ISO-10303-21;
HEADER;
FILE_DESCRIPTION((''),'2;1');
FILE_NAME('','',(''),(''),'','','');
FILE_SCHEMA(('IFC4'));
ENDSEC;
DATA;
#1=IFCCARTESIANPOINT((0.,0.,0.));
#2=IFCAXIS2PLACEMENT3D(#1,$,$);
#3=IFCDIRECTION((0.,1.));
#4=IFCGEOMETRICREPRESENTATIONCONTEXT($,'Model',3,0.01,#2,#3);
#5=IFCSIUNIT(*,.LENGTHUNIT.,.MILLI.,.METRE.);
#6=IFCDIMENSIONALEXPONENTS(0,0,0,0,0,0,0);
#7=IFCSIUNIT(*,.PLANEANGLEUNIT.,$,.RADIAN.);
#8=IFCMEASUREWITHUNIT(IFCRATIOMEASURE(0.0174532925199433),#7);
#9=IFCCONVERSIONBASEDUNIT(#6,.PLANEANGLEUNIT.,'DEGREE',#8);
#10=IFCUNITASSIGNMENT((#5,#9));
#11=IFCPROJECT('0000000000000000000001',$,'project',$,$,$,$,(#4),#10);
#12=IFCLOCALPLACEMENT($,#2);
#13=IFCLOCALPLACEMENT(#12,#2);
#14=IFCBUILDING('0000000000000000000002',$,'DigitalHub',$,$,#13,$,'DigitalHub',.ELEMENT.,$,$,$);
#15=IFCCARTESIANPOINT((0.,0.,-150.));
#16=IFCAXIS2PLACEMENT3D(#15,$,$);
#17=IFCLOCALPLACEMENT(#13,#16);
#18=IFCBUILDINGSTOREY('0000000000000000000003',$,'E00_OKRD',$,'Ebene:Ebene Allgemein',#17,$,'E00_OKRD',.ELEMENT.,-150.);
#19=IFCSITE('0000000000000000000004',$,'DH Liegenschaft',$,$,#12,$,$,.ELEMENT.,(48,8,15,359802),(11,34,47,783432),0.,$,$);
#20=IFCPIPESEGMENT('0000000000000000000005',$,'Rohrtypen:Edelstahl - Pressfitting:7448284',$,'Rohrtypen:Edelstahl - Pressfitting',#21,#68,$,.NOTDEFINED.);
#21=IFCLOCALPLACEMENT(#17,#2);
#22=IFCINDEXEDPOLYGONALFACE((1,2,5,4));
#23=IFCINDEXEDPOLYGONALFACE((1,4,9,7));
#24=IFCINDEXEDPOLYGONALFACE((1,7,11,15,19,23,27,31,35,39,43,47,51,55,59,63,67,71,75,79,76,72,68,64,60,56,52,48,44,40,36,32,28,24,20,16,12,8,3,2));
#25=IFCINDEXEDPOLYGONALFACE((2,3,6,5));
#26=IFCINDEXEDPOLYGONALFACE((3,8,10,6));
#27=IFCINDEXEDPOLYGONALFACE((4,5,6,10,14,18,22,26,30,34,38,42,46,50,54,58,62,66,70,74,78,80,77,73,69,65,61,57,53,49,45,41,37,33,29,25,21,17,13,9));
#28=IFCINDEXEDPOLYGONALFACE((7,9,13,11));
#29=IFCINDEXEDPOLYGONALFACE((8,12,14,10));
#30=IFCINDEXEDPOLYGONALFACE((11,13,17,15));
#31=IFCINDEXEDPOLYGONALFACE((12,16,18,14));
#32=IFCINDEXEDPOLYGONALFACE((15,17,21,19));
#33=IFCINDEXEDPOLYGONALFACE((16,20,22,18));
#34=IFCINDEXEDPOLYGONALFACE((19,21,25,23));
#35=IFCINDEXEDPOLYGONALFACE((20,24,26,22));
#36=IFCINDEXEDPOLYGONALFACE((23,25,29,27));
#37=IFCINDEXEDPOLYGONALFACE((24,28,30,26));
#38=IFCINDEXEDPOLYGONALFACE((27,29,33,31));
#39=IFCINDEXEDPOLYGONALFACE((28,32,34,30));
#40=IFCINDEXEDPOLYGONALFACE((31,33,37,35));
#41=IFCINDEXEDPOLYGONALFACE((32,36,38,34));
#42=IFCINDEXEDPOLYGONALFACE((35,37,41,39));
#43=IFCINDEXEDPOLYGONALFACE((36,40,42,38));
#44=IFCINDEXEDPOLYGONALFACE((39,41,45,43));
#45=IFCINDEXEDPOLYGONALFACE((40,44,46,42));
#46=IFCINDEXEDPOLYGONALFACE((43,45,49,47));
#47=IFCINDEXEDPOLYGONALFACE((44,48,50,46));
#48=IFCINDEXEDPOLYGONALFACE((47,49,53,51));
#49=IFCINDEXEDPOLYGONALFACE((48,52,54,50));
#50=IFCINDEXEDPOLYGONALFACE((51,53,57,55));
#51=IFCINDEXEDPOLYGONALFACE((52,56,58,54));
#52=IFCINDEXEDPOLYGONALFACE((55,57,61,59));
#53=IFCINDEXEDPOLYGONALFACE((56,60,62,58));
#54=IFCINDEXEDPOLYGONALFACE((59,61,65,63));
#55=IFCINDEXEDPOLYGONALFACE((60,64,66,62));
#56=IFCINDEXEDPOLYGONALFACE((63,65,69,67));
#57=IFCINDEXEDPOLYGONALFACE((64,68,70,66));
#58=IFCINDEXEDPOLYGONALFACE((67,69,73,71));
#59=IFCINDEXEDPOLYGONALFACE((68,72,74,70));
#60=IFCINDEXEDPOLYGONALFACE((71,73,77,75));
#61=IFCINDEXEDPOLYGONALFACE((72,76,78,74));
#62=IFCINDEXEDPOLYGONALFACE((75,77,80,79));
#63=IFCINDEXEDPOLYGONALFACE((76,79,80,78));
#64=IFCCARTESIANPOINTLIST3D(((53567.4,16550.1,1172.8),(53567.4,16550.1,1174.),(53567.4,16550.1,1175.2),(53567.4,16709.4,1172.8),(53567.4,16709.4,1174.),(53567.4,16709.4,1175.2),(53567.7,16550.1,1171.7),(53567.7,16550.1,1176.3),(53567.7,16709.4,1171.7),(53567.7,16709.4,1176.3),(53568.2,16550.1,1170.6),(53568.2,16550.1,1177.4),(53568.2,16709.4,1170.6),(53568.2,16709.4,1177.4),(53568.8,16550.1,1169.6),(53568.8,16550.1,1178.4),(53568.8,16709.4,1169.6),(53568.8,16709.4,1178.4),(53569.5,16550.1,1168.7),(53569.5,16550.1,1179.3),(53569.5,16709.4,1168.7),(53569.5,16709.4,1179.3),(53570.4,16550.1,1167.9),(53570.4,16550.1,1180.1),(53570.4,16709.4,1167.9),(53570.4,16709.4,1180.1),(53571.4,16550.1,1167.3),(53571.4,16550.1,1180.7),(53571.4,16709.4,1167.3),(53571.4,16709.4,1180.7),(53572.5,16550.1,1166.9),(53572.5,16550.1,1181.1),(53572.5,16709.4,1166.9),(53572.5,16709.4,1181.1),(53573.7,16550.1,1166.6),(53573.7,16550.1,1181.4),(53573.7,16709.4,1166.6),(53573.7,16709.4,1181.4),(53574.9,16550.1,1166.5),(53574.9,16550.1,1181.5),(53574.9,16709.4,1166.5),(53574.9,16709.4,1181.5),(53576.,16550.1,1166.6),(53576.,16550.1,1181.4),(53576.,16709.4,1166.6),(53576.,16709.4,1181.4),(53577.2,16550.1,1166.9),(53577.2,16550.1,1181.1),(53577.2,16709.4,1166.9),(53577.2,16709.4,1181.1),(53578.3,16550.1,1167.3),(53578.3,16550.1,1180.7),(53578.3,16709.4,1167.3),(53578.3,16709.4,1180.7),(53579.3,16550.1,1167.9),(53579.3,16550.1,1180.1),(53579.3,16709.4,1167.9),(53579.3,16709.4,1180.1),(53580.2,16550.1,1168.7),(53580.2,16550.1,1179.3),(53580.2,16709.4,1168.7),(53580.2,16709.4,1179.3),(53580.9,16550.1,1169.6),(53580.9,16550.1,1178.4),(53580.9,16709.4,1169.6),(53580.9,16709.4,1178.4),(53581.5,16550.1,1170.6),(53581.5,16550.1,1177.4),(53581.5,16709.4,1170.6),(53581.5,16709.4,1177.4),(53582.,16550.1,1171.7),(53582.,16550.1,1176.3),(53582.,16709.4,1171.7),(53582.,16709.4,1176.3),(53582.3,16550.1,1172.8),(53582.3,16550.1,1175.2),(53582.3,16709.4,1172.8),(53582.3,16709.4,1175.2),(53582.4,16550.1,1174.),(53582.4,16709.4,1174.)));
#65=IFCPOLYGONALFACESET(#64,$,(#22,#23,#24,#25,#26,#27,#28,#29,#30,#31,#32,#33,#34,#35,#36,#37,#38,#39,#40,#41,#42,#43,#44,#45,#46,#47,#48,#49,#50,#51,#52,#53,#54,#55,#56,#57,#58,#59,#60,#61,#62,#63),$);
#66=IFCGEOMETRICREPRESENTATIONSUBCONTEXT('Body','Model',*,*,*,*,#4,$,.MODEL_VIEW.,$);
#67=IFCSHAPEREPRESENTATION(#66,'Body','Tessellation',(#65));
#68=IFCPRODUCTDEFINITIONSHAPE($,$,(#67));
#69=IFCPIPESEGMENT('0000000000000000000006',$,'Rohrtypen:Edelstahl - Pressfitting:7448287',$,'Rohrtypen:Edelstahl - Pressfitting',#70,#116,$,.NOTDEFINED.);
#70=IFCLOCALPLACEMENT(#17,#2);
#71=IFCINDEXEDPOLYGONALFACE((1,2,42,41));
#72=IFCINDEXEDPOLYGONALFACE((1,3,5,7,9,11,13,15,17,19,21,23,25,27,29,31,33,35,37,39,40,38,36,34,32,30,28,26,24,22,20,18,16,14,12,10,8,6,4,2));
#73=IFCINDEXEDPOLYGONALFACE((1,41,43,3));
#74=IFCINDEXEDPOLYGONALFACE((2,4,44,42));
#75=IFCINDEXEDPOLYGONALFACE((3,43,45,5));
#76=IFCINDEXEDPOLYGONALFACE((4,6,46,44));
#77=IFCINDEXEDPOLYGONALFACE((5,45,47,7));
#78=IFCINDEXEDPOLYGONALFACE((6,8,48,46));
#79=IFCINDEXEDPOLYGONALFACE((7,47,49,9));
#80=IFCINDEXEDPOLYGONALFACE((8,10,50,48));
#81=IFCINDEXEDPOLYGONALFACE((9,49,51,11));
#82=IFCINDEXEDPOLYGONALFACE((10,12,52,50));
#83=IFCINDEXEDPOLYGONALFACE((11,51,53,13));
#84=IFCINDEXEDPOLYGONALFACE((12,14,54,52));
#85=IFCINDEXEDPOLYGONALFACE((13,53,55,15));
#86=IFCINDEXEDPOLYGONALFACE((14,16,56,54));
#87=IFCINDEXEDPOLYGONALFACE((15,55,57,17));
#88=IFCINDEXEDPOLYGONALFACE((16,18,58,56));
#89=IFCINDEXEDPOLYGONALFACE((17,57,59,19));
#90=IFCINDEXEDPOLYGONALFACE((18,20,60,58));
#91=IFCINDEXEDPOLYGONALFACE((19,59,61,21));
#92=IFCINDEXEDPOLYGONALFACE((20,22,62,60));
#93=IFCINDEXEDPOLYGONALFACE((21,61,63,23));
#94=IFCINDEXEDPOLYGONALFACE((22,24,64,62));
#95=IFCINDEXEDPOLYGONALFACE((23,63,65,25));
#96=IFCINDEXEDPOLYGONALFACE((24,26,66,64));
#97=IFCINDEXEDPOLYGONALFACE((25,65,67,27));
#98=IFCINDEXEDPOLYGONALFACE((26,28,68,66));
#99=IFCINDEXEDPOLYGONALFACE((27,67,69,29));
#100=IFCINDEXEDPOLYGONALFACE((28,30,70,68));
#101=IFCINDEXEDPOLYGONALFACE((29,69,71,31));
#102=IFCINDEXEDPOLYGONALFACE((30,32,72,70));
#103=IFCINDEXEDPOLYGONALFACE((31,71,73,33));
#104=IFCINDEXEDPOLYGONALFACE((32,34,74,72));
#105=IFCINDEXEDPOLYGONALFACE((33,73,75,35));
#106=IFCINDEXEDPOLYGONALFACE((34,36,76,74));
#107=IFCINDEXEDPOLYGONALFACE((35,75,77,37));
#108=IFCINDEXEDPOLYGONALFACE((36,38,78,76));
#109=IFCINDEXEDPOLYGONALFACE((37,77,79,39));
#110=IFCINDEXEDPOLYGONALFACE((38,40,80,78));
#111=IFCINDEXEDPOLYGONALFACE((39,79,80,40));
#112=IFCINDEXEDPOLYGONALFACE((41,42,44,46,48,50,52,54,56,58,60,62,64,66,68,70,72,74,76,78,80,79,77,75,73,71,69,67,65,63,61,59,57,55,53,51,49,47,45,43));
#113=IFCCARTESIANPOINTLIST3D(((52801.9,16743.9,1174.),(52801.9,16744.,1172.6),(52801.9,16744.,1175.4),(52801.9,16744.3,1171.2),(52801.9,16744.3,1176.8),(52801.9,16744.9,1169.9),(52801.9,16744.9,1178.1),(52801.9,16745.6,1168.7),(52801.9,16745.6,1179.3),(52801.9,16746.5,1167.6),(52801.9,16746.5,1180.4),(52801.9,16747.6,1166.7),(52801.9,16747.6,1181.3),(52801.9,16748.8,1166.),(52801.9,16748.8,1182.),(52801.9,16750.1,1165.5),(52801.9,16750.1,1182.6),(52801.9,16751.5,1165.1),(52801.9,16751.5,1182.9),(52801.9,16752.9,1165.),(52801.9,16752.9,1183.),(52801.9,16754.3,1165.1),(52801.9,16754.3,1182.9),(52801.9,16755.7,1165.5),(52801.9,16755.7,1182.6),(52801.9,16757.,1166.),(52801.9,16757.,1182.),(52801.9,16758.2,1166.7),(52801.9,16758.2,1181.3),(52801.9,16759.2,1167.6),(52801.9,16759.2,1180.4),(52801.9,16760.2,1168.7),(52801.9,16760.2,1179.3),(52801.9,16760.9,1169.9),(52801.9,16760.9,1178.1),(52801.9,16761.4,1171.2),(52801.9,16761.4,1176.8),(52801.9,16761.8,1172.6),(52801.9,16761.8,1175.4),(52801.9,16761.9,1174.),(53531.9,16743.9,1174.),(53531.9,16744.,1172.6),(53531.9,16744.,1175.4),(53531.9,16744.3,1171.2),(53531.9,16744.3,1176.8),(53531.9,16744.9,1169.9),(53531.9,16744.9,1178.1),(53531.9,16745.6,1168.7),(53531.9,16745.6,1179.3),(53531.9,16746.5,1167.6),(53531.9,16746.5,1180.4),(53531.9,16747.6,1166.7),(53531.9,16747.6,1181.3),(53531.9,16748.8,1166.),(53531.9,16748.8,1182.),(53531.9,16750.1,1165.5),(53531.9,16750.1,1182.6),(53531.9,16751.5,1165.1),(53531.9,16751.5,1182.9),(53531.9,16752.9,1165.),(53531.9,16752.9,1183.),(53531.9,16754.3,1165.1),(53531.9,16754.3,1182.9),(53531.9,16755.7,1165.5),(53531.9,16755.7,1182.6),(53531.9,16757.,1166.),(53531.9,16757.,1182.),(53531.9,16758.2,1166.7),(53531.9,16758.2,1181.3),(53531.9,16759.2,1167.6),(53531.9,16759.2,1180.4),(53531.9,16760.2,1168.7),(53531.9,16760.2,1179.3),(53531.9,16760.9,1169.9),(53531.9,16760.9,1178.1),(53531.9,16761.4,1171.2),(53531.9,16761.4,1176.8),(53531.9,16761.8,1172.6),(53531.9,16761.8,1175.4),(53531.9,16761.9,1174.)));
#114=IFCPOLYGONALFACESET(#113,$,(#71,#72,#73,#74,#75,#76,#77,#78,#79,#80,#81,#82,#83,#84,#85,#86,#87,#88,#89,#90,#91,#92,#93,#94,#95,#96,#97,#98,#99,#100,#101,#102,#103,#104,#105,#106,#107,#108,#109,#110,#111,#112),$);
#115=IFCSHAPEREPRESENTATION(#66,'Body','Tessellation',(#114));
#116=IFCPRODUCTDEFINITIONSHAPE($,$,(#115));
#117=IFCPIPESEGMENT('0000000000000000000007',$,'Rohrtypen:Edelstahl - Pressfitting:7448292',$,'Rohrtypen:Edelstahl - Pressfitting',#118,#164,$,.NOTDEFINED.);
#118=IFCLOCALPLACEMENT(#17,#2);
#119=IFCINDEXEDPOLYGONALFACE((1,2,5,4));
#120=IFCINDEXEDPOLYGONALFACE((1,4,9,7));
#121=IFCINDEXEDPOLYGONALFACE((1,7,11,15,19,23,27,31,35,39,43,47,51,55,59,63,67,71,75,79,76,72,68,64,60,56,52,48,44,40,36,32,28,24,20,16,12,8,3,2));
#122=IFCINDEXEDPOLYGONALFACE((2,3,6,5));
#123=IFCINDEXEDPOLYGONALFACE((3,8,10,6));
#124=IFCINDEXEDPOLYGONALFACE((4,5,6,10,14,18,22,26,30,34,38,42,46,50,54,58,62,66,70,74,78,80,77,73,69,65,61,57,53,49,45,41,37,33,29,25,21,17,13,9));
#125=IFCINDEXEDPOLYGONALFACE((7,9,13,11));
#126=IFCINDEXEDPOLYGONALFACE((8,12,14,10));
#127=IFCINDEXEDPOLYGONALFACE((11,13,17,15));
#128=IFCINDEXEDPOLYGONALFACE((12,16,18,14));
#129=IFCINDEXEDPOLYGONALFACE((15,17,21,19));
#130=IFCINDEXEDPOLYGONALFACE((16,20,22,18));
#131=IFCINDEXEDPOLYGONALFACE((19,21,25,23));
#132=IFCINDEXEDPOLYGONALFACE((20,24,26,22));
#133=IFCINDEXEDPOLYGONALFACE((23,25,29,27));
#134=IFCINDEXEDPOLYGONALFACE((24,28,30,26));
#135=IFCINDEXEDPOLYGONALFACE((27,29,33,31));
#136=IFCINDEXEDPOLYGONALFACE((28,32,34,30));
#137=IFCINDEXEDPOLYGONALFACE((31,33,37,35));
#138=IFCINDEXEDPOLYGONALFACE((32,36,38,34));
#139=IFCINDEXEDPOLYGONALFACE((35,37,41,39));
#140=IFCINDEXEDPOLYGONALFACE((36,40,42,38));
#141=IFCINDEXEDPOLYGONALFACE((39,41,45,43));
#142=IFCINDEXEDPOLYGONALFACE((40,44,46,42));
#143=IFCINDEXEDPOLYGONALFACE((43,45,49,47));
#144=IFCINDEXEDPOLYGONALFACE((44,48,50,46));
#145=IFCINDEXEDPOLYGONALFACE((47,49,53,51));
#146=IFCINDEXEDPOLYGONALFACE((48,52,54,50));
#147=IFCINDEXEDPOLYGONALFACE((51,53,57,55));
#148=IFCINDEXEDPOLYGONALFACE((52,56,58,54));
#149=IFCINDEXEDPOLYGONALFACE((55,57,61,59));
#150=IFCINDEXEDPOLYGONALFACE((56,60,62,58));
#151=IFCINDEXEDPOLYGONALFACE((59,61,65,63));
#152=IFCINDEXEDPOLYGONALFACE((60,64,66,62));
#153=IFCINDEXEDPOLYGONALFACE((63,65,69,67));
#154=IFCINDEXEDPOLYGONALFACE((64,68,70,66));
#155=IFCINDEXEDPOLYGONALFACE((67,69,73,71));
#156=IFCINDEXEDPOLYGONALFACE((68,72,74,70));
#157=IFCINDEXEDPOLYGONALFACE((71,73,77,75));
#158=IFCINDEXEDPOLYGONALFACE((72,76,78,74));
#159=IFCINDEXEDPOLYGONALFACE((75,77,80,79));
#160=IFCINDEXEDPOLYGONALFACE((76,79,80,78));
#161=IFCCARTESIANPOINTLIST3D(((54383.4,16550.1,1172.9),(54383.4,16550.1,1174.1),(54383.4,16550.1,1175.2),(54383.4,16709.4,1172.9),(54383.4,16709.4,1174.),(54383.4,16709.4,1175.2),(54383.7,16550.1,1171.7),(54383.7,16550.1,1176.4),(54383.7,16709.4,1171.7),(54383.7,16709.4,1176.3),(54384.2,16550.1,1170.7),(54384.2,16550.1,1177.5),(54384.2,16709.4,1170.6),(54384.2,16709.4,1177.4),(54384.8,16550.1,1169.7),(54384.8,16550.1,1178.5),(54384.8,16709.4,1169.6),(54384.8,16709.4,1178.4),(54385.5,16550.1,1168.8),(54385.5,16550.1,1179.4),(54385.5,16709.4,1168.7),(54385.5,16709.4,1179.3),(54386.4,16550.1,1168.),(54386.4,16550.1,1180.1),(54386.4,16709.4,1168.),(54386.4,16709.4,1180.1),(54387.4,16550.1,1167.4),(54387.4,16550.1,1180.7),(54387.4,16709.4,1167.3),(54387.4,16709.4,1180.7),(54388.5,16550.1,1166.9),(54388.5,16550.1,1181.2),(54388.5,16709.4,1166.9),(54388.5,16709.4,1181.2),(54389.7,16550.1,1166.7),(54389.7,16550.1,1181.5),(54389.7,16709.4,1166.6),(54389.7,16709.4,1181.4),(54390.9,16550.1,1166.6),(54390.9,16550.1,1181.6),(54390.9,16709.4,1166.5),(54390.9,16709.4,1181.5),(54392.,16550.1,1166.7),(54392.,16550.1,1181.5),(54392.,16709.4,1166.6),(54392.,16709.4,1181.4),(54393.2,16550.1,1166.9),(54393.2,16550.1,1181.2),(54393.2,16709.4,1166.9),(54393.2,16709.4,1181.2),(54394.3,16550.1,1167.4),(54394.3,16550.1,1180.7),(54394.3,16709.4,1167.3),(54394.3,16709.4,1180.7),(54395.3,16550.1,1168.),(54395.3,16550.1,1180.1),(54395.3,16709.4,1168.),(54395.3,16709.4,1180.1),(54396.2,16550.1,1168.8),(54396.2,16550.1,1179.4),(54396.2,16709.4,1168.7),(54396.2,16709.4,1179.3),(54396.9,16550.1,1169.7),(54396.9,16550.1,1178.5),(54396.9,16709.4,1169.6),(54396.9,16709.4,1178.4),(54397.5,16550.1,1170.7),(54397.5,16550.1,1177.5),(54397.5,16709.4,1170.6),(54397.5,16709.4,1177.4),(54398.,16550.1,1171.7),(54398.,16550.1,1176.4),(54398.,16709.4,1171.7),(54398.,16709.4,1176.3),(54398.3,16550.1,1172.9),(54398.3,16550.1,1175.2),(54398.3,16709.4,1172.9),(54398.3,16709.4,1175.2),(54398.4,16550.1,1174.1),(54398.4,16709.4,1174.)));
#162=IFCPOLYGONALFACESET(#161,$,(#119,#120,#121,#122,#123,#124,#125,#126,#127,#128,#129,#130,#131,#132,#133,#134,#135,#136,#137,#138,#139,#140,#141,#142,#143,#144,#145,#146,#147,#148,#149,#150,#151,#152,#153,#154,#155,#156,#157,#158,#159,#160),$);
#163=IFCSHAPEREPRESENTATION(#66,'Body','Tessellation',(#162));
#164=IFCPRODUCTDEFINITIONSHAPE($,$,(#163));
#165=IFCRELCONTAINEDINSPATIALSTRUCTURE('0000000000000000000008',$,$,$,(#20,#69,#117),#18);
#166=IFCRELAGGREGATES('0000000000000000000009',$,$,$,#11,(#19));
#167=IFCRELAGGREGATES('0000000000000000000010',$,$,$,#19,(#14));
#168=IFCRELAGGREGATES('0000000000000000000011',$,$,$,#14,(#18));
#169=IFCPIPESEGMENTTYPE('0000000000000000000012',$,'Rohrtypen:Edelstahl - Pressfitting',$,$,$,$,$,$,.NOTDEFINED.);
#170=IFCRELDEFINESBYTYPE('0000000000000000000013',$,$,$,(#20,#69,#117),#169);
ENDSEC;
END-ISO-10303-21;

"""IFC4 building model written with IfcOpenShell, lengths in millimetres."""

from ifc_helpers import new_model, entity, si_unit, converted_unit, direction, frame, origin, place, context, subcontext, project, spatial, indexed_curve, outline, extrude, type_object, element, save


model = new_model("IFC4")

# Units and contexts
model_context = context("Model", 3, precision=0.01, world=origin(), true_north=direction((0.0, 1.0)))
body_context = subcontext(model_context, "Body", "Model", "MODEL_VIEW")
ifc_project = project(units=[si_unit("LENGTHUNIT", "METRE", prefix="MILLI"), converted_unit("PLANEANGLEUNIT", "DEGREE", entity("IfcRatioMeasure", 0.0174532925199433), si_unit("PLANEANGLEUNIT", "RADIAN"), dimensions=[0, 0, 0, 0, 0, 0, 0])], contexts=[model_context])

# Site, building, storey
site_placement = place(None, origin())
site = spatial("IfcSite", under=ifc_project, at=site_placement, Name="DH Liegenschaft", CompositionType="ELEMENT", RefLatitude=(48, 8, 15, 359802), RefLongitude=(11, 34, 47, 783432), RefElevation=0.0)
building_placement = place(site_placement, origin())
building = spatial("IfcBuilding", under=site, at=building_placement, Name="DigitalHub", LongName="DigitalHub", CompositionType="ELEMENT")
storey_placement = place(building_placement, frame((0.0, 0.0, -150.0)))
storey = spatial("IfcBuildingStorey", under=building, at=storey_placement, Name="E00_OKRD", ObjectType="Ebene:Ebene Allgemein", LongName="E00_OKRD", CompositionType="ELEMENT", Elevation=-150.0)

# Pipe segments
pipe_segment_type_1 = type_object("IfcPipeSegmentType", Name="Rohrtypen:Edelstahl - Pressfitting", PredefinedType="NOTDEFINED")
pipe_segment_1_placement = place(storey_placement, frame((53565.8, 16550.1, 1164.9)))
element("IfcPipeSegment", 1, at=pipe_segment_1_placement, inside=storey, type_object=pipe_segment_type_1, Name="Rohrtypen:Edelstahl - Pressfitting:7448284", ObjectType="Rohrtypen:Edelstahl - Pressfitting", PredefinedType="NOTDEFINED", context=body_context, shape_type="SweptSolid", body=[
    extrude(outline(indexed_curve([(7.5, 0.0), (7.4, 1.2), (7.1, 2.3), (6.7, 3.4), (6.1, 4.4), (5.3, 5.3), (4.4, 6.1), (3.4, 6.7), (2.3, 7.1), (1.2, 7.4), (0.0, 7.5), (-1.2, 7.4), (-2.3, 7.1), (-3.4, 6.7), (-4.4, 6.1), (-5.3, 5.3), (-6.1, 4.4), (-6.7, 3.4), (-7.1, 2.3), (-7.4, 1.2), (-7.5, 0.0), (-7.4, -1.2), (-7.1, -2.3), (-6.7, -3.4), (-6.1, -4.4), (-5.3, -5.3), (-4.4, -6.1), (-3.4, -6.7), (-2.3, -7.1), (-1.2, -7.4), (0.0, -7.5), (1.2, -7.4), (2.3, -7.1), (3.4, -6.7), (4.4, -6.1), (5.3, -5.3), (6.1, -4.4), (6.7, -3.4), (7.1, -2.3), (7.4, -1.2), (7.5, 0.0)], self_intersect=False)), frame((9.1, 0.0, 9.1), z_axis=(0.0, 1.0, 0.000054), x_axis=(-1.0, 0.0, 0.0)), (0.0, 0.0, 1.0), 159.2),
])
pipe_segment_2_placement = place(storey_placement, frame((52801.9, 16742.3, 1163.4)))
element("IfcPipeSegment", 2, at=pipe_segment_2_placement, inside=storey, type_object=pipe_segment_type_1, Name="Rohrtypen:Edelstahl - Pressfitting:7448287", ObjectType="Rohrtypen:Edelstahl - Pressfitting", PredefinedType="NOTDEFINED", context=body_context, shape_type="SweptSolid", body=[
    extrude(outline(indexed_curve([(9.0, 0.0), (8.9, 1.4), (8.6, 2.8), (8.0, 4.1), (7.3, 5.3), (6.4, 6.4), (5.3, 7.3), (4.1, 8.0), (2.8, 8.6), (1.4, 8.9), (0.0, 9.0), (-1.4, 8.9), (-2.8, 8.6), (-4.1, 8.0), (-5.3, 7.3), (-6.4, 6.4), (-7.3, 5.3), (-8.0, 4.1), (-8.6, 2.8), (-8.9, 1.4), (-9.0, 0.0), (-8.9, -1.4), (-8.6, -2.8), (-8.0, -4.1), (-7.3, -5.3), (-6.4, -6.4), (-5.3, -7.3), (-4.1, -8.0), (-2.8, -8.6), (-1.4, -8.9), (0.0, -9.0), (1.4, -8.9), (2.8, -8.6), (4.1, -8.0), (5.3, -7.3), (6.4, -6.4), (7.3, -5.3), (8.0, -4.1), (8.6, -2.8), (8.9, -1.4), (9.0, 0.0)], self_intersect=False)), frame((0.0, 10.6, 10.6), z_axis=(1.0, 0.0, 0.0), x_axis=(0.0, -1.0, 0.0)), (0.0, 0.0, 1.0), 730.0),
])
pipe_segment_3_placement = place(storey_placement, frame((54381.8, 16550.1, 1164.9)))
element("IfcPipeSegment", 3, at=pipe_segment_3_placement, inside=storey, type_object=pipe_segment_type_1, Name="Rohrtypen:Edelstahl - Pressfitting:7448292", ObjectType="Rohrtypen:Edelstahl - Pressfitting", PredefinedType="NOTDEFINED", context=body_context, shape_type="SweptSolid", body=[
    extrude(outline(indexed_curve([(7.5, 0.0), (7.4, 1.2), (7.1, 2.3), (6.7, 3.4), (6.1, 4.4), (5.3, 5.3), (4.4, 6.1), (3.4, 6.7), (2.3, 7.1), (1.2, 7.4), (0.0, 7.5), (-1.2, 7.4), (-2.3, 7.1), (-3.4, 6.7), (-4.4, 6.1), (-5.3, 5.3), (-6.1, 4.4), (-6.7, 3.4), (-7.1, 2.3), (-7.4, 1.2), (-7.5, 0.0), (-7.4, -1.2), (-7.1, -2.3), (-6.7, -3.4), (-6.1, -4.4), (-5.3, -5.3), (-4.4, -6.1), (-3.4, -6.7), (-2.3, -7.1), (-1.2, -7.4), (0.0, -7.5), (1.2, -7.4), (2.3, -7.1), (3.4, -6.7), (4.4, -6.1), (5.3, -5.3), (6.1, -4.4), (6.7, -3.4), (7.1, -2.3), (7.4, -1.2), (7.5, 0.0)], self_intersect=False)), frame((9.1, 0.0, 9.1), z_axis=(0.0, 1.0, -0.0002), x_axis=(-1.0, 0.0, 0.0)), (0.0, 0.0, 1.0), 159.2),
])

save(model, "model.ifc")
